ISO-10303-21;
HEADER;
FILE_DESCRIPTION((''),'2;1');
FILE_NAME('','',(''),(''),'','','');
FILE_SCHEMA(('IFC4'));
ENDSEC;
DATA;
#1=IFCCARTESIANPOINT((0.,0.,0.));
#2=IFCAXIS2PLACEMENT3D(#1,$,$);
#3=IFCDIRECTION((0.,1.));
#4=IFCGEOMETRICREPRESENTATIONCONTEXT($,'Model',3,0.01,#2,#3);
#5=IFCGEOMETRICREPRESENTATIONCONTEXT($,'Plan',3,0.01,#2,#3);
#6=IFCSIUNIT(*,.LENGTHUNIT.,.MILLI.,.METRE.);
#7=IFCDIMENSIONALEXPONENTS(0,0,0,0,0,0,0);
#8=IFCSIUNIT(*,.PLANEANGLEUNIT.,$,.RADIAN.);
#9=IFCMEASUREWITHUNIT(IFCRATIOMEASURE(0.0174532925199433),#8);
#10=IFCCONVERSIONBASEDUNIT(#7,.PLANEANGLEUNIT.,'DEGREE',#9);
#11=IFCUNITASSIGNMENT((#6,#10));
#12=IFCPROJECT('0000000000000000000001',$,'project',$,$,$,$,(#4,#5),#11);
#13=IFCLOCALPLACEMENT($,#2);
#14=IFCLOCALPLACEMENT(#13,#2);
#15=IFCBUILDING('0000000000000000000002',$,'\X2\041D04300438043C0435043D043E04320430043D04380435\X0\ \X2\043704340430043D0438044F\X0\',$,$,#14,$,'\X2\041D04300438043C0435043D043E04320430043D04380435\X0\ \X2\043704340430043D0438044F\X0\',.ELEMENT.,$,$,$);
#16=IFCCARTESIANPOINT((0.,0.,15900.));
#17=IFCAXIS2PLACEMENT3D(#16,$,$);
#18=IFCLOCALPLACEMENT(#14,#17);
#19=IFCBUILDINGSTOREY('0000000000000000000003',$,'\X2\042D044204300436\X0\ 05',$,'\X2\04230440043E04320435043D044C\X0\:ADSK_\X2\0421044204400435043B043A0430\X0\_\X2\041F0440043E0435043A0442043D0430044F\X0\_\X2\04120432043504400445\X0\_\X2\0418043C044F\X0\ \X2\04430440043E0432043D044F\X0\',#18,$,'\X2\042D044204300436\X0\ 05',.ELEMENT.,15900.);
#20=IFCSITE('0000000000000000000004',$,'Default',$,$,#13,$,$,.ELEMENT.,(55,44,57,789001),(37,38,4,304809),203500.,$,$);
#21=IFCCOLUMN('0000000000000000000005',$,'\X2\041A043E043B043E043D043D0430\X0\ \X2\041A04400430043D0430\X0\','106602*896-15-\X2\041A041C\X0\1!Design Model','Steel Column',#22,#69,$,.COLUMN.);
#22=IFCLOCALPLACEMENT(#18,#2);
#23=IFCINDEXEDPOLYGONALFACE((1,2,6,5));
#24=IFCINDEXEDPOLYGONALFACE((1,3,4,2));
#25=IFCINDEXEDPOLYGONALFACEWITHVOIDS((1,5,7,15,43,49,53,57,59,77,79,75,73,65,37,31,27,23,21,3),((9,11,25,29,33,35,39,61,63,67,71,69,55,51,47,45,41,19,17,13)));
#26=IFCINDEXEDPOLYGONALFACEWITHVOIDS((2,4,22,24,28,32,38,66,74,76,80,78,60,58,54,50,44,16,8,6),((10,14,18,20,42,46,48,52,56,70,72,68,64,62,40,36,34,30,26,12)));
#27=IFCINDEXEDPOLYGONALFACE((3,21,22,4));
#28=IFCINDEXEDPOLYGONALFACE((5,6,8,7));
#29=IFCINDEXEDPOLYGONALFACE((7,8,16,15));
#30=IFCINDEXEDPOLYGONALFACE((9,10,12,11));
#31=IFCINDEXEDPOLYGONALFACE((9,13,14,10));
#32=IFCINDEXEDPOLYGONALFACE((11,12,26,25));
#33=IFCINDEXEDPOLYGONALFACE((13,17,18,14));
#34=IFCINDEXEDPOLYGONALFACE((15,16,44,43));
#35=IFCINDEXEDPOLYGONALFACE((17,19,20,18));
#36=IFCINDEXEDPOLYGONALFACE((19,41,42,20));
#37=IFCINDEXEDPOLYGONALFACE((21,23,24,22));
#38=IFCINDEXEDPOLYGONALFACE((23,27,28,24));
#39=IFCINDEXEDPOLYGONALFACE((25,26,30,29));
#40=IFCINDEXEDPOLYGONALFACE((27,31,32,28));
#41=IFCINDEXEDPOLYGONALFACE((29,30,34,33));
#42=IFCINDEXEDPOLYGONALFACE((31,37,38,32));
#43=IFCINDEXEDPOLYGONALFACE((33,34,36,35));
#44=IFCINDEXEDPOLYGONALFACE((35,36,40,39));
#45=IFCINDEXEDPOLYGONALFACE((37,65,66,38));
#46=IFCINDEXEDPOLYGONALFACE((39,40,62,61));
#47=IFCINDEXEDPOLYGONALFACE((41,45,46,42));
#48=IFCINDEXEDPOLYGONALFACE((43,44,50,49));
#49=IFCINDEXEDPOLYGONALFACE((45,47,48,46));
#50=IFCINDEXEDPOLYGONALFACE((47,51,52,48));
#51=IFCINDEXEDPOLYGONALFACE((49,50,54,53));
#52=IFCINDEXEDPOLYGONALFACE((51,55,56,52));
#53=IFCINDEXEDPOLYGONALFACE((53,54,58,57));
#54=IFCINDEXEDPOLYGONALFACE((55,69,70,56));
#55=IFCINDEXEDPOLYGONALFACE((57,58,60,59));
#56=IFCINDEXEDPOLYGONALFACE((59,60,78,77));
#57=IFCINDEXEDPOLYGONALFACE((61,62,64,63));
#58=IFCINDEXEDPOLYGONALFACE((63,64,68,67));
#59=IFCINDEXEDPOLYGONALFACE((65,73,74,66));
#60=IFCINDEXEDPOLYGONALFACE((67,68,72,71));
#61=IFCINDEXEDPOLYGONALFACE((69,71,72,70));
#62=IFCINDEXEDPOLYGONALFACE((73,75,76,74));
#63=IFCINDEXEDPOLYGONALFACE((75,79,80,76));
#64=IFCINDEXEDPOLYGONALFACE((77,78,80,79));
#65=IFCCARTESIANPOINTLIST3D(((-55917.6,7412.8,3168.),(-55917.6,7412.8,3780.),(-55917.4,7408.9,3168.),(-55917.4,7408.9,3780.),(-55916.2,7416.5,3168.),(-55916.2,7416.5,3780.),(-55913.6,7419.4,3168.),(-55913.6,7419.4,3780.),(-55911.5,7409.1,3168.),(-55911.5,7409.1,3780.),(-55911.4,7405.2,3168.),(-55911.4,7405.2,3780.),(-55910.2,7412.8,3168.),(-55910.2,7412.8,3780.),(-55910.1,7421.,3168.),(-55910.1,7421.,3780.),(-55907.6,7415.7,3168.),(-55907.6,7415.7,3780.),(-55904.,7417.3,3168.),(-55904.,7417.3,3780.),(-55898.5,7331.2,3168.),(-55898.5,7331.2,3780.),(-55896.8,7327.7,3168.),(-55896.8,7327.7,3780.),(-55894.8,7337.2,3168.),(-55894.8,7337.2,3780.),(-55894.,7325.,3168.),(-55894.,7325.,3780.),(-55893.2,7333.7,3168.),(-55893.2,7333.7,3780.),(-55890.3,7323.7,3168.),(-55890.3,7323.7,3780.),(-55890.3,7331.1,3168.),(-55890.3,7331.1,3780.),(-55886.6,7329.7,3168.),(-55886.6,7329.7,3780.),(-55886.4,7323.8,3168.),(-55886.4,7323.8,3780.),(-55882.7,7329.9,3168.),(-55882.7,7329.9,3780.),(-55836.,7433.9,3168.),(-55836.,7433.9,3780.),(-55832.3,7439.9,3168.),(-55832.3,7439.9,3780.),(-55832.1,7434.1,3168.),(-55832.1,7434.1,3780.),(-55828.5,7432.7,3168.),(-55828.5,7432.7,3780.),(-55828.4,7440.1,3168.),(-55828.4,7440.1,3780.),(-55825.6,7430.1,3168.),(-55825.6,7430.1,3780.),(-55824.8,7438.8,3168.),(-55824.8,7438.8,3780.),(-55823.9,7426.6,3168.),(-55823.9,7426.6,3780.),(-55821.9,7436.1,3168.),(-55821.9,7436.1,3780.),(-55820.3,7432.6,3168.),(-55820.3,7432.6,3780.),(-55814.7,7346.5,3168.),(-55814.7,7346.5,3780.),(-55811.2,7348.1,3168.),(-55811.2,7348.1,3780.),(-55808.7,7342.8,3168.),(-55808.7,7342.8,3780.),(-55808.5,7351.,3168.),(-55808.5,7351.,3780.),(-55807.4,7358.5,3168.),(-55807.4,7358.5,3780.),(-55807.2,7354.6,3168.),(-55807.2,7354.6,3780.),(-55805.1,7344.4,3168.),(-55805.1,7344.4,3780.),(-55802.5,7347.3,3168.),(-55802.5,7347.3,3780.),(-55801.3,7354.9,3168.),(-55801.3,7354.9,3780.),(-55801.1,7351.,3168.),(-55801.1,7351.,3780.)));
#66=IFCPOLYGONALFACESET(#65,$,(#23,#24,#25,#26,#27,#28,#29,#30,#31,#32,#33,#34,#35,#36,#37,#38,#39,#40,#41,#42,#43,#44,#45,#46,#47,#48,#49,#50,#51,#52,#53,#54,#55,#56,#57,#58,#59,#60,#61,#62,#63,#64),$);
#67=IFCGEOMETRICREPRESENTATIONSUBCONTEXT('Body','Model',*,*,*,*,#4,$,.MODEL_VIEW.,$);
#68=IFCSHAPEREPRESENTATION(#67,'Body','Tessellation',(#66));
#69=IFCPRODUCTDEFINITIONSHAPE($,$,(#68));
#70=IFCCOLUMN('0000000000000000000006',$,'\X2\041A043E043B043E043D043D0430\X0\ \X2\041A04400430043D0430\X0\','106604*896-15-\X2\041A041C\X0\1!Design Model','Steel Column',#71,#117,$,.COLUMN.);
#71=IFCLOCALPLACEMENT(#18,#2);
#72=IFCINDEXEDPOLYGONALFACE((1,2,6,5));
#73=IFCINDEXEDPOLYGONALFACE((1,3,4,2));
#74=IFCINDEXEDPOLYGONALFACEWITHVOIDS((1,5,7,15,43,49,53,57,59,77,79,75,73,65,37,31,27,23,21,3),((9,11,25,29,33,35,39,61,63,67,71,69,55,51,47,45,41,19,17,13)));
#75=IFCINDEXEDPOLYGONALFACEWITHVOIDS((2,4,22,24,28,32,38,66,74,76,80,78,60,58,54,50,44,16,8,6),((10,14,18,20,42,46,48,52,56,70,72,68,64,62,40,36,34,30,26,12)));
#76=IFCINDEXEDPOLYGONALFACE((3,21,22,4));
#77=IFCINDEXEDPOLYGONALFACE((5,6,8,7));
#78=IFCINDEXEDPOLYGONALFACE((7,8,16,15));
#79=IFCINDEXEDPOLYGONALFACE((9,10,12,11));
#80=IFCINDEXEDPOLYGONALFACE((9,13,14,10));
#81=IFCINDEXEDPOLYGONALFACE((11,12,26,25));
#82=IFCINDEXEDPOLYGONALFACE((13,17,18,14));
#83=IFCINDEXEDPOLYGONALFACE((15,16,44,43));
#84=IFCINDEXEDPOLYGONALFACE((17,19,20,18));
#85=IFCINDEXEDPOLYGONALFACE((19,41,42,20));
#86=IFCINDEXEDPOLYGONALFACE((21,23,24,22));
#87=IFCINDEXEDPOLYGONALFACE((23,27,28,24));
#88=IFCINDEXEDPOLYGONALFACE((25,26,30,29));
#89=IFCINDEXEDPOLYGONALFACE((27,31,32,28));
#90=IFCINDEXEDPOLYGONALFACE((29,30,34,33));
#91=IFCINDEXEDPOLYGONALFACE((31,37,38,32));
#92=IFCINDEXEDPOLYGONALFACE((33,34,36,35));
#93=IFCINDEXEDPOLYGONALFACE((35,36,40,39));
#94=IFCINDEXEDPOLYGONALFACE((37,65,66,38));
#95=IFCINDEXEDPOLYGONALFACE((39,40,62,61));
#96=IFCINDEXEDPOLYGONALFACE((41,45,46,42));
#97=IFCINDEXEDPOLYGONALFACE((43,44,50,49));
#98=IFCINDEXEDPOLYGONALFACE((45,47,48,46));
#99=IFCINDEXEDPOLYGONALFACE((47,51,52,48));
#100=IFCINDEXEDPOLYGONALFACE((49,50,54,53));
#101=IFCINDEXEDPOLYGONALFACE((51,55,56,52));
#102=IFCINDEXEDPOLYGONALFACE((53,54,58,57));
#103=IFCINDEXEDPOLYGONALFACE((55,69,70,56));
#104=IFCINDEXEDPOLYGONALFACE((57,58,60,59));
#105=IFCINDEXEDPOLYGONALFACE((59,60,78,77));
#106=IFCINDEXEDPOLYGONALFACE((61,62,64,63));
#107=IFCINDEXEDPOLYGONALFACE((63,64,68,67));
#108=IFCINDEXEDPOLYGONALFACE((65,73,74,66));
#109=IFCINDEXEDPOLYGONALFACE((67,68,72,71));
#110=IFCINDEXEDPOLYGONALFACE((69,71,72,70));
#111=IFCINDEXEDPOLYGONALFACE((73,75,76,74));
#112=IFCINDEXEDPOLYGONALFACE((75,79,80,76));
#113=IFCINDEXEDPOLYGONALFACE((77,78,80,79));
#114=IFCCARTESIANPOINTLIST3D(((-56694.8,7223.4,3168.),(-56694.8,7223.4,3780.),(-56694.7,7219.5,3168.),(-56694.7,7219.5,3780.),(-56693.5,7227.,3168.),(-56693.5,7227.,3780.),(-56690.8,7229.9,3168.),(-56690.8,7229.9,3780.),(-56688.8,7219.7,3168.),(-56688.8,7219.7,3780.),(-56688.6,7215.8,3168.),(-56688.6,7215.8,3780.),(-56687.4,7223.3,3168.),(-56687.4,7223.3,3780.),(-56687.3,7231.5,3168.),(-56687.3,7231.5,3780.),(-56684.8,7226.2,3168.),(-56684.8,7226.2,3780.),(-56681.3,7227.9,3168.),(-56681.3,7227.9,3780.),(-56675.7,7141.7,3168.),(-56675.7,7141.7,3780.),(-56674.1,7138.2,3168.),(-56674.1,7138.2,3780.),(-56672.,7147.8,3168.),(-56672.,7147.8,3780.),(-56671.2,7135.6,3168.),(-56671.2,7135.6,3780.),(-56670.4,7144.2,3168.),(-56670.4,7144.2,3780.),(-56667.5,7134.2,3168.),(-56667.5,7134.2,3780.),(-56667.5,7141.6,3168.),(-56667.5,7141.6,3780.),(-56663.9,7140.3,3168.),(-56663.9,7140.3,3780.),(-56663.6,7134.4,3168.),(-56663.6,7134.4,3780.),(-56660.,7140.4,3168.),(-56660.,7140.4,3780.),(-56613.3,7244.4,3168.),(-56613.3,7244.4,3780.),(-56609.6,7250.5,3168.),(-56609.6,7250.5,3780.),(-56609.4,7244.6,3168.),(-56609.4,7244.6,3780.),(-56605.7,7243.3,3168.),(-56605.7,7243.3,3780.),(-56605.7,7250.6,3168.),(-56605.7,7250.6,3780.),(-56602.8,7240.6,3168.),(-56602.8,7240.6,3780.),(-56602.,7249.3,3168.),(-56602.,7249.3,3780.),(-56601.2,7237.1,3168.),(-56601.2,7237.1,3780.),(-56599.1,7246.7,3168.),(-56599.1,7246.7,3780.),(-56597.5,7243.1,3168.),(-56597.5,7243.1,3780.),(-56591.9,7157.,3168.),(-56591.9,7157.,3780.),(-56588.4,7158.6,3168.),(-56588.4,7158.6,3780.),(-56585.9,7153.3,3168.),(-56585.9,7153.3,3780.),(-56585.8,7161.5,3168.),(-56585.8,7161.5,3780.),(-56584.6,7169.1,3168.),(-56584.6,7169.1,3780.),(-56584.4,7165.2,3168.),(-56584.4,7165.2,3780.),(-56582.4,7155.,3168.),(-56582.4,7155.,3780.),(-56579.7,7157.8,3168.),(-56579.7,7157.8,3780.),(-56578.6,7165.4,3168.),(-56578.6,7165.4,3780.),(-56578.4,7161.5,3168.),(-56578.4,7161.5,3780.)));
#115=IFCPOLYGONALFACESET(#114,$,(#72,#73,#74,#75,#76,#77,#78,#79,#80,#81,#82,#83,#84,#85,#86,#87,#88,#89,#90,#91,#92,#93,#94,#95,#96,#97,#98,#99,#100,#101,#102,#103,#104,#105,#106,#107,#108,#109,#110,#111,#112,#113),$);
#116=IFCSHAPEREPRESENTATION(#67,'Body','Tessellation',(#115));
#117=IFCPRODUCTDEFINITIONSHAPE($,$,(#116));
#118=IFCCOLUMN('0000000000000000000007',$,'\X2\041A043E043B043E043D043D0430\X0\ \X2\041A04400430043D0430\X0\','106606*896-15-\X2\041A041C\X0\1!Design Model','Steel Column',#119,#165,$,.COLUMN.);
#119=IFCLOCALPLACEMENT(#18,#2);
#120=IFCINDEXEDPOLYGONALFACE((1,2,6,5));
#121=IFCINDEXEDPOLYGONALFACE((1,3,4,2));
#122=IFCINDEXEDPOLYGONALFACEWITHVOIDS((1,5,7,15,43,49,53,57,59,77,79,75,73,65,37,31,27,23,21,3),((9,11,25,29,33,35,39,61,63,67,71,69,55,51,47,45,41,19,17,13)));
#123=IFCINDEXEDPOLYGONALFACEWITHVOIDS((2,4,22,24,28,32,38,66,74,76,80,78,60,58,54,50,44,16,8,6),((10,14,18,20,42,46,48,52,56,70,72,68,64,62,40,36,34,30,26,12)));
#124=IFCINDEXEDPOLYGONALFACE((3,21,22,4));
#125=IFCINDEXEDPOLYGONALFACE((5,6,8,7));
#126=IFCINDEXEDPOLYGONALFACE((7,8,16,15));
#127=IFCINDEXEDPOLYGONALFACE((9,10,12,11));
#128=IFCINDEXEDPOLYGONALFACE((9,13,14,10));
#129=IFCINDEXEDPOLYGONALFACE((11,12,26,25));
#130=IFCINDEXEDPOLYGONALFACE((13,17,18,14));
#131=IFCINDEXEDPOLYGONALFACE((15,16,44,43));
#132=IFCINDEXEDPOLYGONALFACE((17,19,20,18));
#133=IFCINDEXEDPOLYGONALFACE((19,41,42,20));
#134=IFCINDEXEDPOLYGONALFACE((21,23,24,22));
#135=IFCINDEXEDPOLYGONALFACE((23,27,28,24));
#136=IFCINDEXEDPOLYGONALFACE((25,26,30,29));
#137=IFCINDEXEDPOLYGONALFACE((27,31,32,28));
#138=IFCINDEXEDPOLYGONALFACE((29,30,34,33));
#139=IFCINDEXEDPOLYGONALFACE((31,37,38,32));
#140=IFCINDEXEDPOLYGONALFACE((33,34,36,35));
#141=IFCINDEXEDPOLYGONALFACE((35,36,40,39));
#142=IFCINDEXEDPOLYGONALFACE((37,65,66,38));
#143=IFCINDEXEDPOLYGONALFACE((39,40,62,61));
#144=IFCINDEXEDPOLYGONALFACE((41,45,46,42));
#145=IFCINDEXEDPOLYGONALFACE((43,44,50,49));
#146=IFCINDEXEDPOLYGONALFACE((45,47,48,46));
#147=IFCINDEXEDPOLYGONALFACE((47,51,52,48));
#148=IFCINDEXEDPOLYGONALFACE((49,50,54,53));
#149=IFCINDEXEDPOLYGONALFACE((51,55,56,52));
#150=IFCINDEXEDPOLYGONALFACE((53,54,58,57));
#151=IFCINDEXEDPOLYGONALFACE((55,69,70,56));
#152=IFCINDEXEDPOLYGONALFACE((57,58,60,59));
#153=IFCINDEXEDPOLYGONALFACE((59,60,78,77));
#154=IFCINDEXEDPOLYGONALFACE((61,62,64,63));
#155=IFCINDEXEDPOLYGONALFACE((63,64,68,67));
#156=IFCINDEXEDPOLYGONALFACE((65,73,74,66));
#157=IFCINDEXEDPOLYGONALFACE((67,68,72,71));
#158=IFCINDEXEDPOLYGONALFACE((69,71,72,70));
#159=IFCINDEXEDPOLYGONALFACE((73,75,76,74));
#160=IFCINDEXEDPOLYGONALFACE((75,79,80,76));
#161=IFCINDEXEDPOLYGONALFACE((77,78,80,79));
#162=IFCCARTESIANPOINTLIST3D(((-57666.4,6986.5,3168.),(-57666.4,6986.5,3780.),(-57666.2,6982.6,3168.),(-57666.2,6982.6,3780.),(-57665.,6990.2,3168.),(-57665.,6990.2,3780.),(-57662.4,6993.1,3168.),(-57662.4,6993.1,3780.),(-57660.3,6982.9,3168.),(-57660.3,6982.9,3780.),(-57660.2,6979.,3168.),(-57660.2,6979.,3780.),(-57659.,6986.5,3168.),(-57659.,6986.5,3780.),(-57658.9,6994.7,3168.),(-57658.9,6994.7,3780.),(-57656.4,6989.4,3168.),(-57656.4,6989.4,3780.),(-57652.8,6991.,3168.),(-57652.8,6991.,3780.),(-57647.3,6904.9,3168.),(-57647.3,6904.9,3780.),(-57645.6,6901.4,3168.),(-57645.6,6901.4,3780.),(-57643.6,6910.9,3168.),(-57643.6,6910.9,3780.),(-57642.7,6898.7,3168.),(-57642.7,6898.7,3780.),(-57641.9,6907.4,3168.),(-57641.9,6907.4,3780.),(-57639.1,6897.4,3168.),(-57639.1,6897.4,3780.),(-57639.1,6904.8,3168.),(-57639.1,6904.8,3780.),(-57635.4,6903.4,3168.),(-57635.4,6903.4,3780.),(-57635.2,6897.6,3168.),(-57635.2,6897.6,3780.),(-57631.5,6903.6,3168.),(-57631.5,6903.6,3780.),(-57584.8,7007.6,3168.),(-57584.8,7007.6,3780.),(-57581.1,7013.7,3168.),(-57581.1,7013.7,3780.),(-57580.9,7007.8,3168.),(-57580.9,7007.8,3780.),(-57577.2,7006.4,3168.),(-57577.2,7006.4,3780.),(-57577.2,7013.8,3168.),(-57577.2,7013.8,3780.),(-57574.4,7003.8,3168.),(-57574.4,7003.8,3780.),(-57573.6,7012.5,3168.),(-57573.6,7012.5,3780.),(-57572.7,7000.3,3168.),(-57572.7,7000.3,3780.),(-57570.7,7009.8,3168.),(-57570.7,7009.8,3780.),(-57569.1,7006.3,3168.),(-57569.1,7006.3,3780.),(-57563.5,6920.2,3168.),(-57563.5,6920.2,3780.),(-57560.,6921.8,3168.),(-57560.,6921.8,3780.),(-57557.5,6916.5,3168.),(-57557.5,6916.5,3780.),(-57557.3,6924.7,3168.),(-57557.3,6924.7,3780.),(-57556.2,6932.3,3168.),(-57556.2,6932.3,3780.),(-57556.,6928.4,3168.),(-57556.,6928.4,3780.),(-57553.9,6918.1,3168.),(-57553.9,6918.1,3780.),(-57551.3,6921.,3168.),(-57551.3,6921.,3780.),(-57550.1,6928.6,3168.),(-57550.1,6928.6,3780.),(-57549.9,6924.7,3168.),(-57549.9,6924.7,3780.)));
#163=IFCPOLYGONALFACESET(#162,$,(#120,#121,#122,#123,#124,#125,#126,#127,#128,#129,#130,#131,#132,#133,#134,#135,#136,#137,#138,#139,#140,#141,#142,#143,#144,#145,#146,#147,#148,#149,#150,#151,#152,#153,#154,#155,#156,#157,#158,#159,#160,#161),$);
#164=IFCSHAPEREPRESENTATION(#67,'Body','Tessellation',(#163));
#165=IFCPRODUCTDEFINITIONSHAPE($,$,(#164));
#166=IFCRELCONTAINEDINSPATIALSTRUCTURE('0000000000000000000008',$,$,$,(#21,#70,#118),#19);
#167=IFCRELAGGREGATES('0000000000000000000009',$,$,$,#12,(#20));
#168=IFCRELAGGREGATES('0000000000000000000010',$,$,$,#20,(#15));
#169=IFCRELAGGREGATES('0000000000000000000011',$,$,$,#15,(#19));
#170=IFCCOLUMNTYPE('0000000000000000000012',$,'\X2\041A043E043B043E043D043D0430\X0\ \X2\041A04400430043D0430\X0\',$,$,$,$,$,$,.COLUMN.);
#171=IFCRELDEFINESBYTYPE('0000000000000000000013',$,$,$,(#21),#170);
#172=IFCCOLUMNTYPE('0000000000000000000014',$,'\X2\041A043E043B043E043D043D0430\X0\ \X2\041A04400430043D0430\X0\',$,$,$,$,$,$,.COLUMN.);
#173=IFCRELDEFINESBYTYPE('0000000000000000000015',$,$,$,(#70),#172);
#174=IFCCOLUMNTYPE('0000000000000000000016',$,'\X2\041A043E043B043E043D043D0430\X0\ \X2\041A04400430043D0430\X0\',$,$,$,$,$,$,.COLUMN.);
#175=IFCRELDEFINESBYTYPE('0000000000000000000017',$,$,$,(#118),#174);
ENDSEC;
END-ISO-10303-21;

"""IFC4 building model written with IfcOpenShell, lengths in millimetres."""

from ifc_helpers import new_model, entity, si_unit, converted_unit, direction, frame, origin, place, context, subcontext, project, spatial, indexed_curve, outline, extrude, type_object, element, save


model = new_model("IFC4")

# Units and contexts
model_context = context("Model", 3, precision=0.01, world=origin(), true_north=direction((0.0, 1.0)))
plan_context = context("Plan", 3, precision=0.01, world=origin(), true_north=direction((0.0, 1.0)))
body_context = subcontext(model_context, "Body", "Model", "MODEL_VIEW")
ifc_project = project(units=[si_unit("LENGTHUNIT", "METRE", prefix="MILLI"), converted_unit("PLANEANGLEUNIT", "DEGREE", entity("IfcRatioMeasure", 0.0174532925199433), si_unit("PLANEANGLEUNIT", "RADIAN"), dimensions=[0, 0, 0, 0, 0, 0, 0])], contexts=[model_context, plan_context])

# Site, building, storey
site_placement = place(None, origin())
site = spatial("IfcSite", under=ifc_project, at=site_placement, Name="Default", CompositionType="ELEMENT", RefLatitude=(55, 44, 57, 789001), RefLongitude=(37, 38, 4, 304809), RefElevation=203500.0)
building_placement = place(site_placement, origin())
building = spatial("IfcBuilding", under=site, at=building_placement, Name="Наименование здания", LongName="Наименование здания", CompositionType="ELEMENT")
storey_placement = place(building_placement, frame((0.0, 0.0, 15900.0)))
storey = spatial("IfcBuildingStorey", under=building, at=storey_placement, Name="Этаж 05", ObjectType="Уровень:ADSK_Стрелка_Проектная_Вверх_Имя уровня", LongName="Этаж 05", CompositionType="ELEMENT", Elevation=15900.0)

# Columns
column_type_1 = type_object("IfcColumnType", Name="Колонна Крана", PredefinedType="COLUMN")
column_1_placement = place(storey_placement, origin())
element("IfcColumn", 1, at=column_1_placement, inside=storey, type_object=column_type_1, Name="Колонна Крана", Description="106602*896-15-КМ1!Design Model", ObjectType="Steel Column", PredefinedType="COLUMN", context=body_context, shape_type="SweptSolid", body=[
    extrude(outline(indexed_curve([(29.5, -56.8), (33.4, -56.8), (37.0, -55.3), (39.7, -52.6), (41.2, -49.0), (56.8, 29.5), (56.8, 33.4), (55.3, 37.0), (52.6, 39.7), (49.0, 41.2), (-29.5, 56.8), (-33.4, 56.8), (-37.0, 55.3), (-39.7, 52.6), (-41.2, 49.0), (-56.8, -29.5), (-56.8, -33.4), (-55.3, -37.0), (-52.6, -39.7), (-49.0, -41.2), (29.5, -56.8)], self_intersect=False), holes=[indexed_curve([(-43.1, -37.3), (-46.7, -35.8), (-49.5, -33.1), (-51.0, -29.5), (-51.0, -25.5), (-37.3, 43.1), (-35.8, 46.7), (-33.1, 49.5), (-29.5, 51.0), (-25.5, 51.0), (43.1, 37.3), (46.7, 35.8), (49.5, 33.1), (51.0, 29.5), (51.0, 25.5), (37.3, -43.1), (35.8, -46.7), (33.1, -49.5), (29.5, -51.0), (25.5, -51.0), (-43.1, -37.3)], self_intersect=False)]), frame((-55859.4, 7381.9, 3168.0), z_axis=(0.0, 0.0, 1.0), x_axis=(0.906681, 0.421816, 0.0)), (0.0, 0.0, 1.0), 612.0),
])
column_type_2 = type_object("IfcColumnType", Name="Колонна Крана", PredefinedType="COLUMN")
column_2_placement = place(storey_placement, origin())
element("IfcColumn", 2, at=column_2_placement, inside=storey, type_object=column_type_2, Name="Колонна Крана", Description="106604*896-15-КМ1!Design Model", ObjectType="Steel Column", PredefinedType="COLUMN", context=body_context, shape_type="SweptSolid", body=[
    extrude(outline(indexed_curve([(29.5, -56.8), (33.4, -56.8), (37.0, -55.3), (39.7, -52.6), (41.2, -49.0), (56.8, 29.5), (56.8, 33.4), (55.3, 37.0), (52.6, 39.7), (49.0, 41.2), (-29.5, 56.8), (-33.4, 56.8), (-37.0, 55.3), (-39.7, 52.6), (-41.2, 49.0), (-56.8, -29.5), (-56.8, -33.4), (-55.3, -37.0), (-52.6, -39.7), (-49.0, -41.2), (29.5, -56.8)], self_intersect=False), holes=[indexed_curve([(-43.1, -37.3), (-46.7, -35.8), (-49.5, -33.1), (-51.0, -29.5), (-51.0, -25.5), (-37.3, 43.1), (-35.8, 46.7), (-33.1, 49.5), (-29.5, 51.0), (-25.5, 51.0), (43.1, 37.3), (46.7, 35.8), (49.5, 33.1), (51.0, 29.5), (51.0, 25.5), (37.3, -43.1), (35.8, -46.7), (33.1, -49.5), (29.5, -51.0), (25.5, -51.0), (-43.1, -37.3)], self_intersect=False)]), frame((-56636.6, 7192.4, 3168.0), z_axis=(0.0, 0.0, 1.0), x_axis=(0.906681, 0.421816, 0.0)), (0.0, 0.0, 1.0), 612.0),
])
column_type_3 = type_object("IfcColumnType", Name="Колонна Крана", PredefinedType="COLUMN")
column_3_placement = place(storey_placement, origin())
element("IfcColumn", 3, at=column_3_placement, inside=storey, type_object=column_type_3, Name="Колонна Крана", Description="106606*896-15-КМ1!Design Model", ObjectType="Steel Column", PredefinedType="COLUMN", context=body_context, shape_type="SweptSolid", body=[
    extrude(outline(indexed_curve([(29.5, -56.8), (33.4, -56.8), (37.0, -55.3), (39.7, -52.6), (41.2, -49.0), (56.8, 29.5), (56.8, 33.4), (55.3, 37.0), (52.6, 39.7), (49.0, 41.2), (-29.5, 56.8), (-33.4, 56.8), (-37.0, 55.3), (-39.7, 52.6), (-41.2, 49.0), (-56.8, -29.5), (-56.8, -33.4), (-55.3, -37.0), (-52.6, -39.7), (-49.0, -41.2), (29.5, -56.8)], self_intersect=False), holes=[indexed_curve([(-43.1, -37.3), (-46.7, -35.8), (-49.5, -33.1), (-51.0, -29.5), (-51.0, -25.5), (-37.3, 43.1), (-35.8, 46.7), (-33.1, 49.5), (-29.5, 51.0), (-25.5, 51.0), (43.1, 37.3), (46.7, 35.8), (49.5, 33.1), (51.0, 29.5), (51.0, 25.5), (37.3, -43.1), (35.8, -46.7), (33.1, -49.5), (29.5, -51.0), (25.5, -51.0), (-43.1, -37.3)], self_intersect=False)]), frame((-57608.2, 6955.6, 3168.0), z_axis=(0.0, 0.0, 1.0), x_axis=(0.906681, 0.421816, 0.0)), (0.0, 0.0, 1.0), 612.0),
])

save(model, "model.ifc")
